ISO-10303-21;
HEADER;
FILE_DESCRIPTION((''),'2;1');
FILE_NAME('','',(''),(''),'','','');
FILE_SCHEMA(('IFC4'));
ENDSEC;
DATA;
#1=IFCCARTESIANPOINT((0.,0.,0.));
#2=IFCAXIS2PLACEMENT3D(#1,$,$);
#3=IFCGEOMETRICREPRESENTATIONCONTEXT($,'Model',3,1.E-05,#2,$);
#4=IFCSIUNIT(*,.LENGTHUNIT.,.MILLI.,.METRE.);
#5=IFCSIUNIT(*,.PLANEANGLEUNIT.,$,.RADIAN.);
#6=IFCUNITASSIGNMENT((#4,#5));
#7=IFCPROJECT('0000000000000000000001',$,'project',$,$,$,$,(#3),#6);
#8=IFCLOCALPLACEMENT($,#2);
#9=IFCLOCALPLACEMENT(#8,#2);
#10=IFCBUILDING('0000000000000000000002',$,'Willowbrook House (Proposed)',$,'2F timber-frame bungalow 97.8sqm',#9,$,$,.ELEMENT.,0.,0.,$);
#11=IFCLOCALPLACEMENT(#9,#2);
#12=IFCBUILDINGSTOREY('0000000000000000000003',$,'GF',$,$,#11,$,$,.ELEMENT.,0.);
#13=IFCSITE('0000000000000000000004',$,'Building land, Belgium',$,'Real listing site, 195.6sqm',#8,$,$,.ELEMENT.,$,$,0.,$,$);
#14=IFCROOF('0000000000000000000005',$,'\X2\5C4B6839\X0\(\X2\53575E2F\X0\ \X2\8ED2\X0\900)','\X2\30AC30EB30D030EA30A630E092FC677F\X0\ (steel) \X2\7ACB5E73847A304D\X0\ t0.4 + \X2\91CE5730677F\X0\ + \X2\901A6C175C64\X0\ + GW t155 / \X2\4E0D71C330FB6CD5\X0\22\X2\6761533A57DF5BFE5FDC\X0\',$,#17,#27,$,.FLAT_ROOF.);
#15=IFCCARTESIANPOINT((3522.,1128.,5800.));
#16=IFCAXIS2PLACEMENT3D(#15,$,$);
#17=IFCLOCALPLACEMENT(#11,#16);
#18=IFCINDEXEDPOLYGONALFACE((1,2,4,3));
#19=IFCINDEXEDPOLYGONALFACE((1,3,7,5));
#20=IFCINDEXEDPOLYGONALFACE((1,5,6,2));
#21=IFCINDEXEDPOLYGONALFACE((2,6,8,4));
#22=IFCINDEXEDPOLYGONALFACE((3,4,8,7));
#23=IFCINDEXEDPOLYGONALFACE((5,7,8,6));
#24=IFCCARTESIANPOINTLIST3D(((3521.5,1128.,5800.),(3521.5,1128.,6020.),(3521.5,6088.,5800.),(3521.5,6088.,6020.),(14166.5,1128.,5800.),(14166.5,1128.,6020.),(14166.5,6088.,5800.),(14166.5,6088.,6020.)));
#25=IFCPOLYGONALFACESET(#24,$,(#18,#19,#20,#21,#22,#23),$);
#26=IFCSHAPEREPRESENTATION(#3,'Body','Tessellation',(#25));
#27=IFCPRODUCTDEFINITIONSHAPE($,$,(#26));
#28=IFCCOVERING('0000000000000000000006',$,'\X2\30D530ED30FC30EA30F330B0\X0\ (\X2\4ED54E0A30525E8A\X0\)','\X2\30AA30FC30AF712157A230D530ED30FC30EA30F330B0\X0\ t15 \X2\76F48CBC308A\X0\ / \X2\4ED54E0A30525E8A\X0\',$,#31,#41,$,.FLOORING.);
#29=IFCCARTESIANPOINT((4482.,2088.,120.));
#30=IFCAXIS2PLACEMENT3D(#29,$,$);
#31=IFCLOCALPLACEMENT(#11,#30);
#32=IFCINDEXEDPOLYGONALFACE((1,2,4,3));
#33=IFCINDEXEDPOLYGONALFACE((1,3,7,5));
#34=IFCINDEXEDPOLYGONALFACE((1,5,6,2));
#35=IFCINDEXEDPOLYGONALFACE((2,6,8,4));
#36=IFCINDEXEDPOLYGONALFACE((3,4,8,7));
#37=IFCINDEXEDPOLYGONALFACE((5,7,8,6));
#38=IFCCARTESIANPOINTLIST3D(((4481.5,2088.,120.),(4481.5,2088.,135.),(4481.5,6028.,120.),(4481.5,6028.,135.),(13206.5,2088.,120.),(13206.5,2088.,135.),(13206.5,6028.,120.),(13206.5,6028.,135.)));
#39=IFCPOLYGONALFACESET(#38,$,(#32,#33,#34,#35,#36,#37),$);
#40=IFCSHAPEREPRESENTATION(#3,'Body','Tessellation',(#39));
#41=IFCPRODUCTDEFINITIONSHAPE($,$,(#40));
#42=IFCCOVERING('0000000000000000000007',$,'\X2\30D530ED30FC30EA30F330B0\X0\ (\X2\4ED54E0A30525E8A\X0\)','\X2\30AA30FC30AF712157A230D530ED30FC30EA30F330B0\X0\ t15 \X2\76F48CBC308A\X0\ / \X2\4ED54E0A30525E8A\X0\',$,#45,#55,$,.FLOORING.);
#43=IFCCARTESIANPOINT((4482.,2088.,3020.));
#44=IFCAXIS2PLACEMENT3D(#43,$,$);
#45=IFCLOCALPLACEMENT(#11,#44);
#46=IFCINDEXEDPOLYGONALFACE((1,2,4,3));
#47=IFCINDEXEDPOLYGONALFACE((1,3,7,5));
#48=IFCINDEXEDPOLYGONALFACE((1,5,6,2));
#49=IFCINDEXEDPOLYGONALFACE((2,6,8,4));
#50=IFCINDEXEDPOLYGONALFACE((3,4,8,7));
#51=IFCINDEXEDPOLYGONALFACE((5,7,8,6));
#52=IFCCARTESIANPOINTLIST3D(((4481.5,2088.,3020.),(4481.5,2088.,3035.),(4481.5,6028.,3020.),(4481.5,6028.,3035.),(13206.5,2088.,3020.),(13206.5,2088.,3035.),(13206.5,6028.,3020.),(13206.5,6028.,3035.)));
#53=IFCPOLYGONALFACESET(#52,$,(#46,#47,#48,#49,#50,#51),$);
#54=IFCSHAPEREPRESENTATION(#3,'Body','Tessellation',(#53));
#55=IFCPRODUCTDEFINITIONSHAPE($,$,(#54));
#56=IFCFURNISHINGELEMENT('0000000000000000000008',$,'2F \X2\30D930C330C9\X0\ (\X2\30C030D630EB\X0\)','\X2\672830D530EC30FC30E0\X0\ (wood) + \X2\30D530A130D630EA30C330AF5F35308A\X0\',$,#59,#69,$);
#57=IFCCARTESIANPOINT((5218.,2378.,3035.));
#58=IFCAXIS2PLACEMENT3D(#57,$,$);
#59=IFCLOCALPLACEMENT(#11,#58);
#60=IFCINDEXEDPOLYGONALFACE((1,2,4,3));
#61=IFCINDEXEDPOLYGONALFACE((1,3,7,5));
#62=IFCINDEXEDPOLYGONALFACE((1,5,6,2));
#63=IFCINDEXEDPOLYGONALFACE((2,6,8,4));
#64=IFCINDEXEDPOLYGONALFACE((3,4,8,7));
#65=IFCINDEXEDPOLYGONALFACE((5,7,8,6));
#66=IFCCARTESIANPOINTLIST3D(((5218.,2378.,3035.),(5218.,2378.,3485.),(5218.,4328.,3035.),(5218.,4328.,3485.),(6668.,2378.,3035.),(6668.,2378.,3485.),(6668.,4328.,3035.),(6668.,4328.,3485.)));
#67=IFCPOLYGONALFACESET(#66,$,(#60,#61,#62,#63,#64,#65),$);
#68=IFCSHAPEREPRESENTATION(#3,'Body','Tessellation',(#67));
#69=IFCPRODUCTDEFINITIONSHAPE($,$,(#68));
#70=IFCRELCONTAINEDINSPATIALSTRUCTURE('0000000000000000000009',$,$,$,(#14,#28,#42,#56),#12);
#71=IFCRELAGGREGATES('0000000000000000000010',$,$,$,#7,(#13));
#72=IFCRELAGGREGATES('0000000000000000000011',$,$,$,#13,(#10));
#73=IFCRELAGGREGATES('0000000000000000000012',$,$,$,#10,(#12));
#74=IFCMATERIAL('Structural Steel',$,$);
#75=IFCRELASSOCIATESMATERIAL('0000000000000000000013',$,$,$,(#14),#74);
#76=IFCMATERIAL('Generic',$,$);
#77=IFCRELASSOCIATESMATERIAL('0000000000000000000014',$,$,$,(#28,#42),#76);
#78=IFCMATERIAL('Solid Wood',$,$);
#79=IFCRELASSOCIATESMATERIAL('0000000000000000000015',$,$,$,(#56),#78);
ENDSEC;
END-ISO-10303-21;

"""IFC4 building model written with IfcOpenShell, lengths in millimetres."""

from ifc_helpers import new_model, si_unit, frame, frame_2d, origin, place, context, project, spatial, rectangle, extrude, material, element, save


model = new_model("IFC4")

# Units and contexts
model_context = context("Model", 3, precision=1e-05, world=origin())
ifc_project = project(units=[si_unit("LENGTHUNIT", "METRE", prefix="MILLI"), si_unit("PLANEANGLEUNIT", "RADIAN")], contexts=[model_context])

# Site, building, storey
site_placement = place(None, origin())
site = spatial("IfcSite", under=ifc_project, at=site_placement, Name="Building land, Belgium", ObjectType="Real listing site, 195.6sqm", CompositionType="ELEMENT", RefElevation=0.0)
building_placement = place(site_placement, origin())
building = spatial("IfcBuilding", under=site, at=building_placement, Name="Willowbrook House (Proposed)", ObjectType="2F timber-frame bungalow 97.8sqm", CompositionType="ELEMENT", ElevationOfRefHeight=0.0, ElevationOfTerrain=0.0)
storey_placement = place(building_placement, origin())
storey = spatial("IfcBuildingStorey", under=building, at=storey_placement, Name="GF", CompositionType="ELEMENT", Elevation=0.0)

# Shared definitions
ifc_material_1 = material(Name="Solid Wood")

# Roof
ifc_material_2 = material(Name="Structural Steel")
for number, where, name in (
    (1, (3522.0, 1128.0, 5800.0), "屋根(南帯 軒900)"),
):
    element("IfcRoof", number, at=place(storey_placement, frame(where)), inside=storey, material=ifc_material_2, Name=name, Description="ガルバリウム鋼板 (steel) 立平葺き t0.4 + 野地板 + 通気層 + GW t155 / 不燃・法22条区域対応", PredefinedType="FLAT_ROOF", context=model_context, shape_type="SweptSolid", body=[
        extrude(rectangle(XDim=10645.0, YDim=4960.0, at=frame_2d((5322.0, 2480.0))), frame((3522.0, 1128.0, 5800.0)), (0.0, 0.0, 1.0), 220.0),
    ])

# Coverings
ifc_material_3 = material(Name="Generic")
covering_1_placement = place(storey_placement, frame((4482.0, 2088.0, 120.0)))
element("IfcCovering", 2, at=covering_1_placement, inside=storey, material=ifc_material_3, Name="フローリング (仕上げ床)", Description="オーク無垢フローリング t15 直貼り / 仕上げ床", PredefinedType="FLOORING", context=model_context, shape_type="SweptSolid", body=[
    extrude(rectangle(XDim=8725.0, YDim=3940.0, at=frame_2d((4362.0, 1970.0))), frame((4482.0, 2088.0, 120.0)), (0.0, 0.0, 1.0), 15.0),
])
covering_2_placement = place(storey_placement, frame((4482.0, 2088.0, 3020.0)))
element("IfcCovering", 3, at=covering_2_placement, inside=storey, material=ifc_material_3, Name="フローリング (仕上げ床)", Description="オーク無垢フローリング t15 直貼り / 仕上げ床", PredefinedType="FLOORING", context=model_context, shape_type="SweptSolid", body=[
    extrude(rectangle(XDim=8725.0, YDim=3940.0, at=frame_2d((4362.0, 1970.0))), frame((4482.0, 2088.0, 3020.0)), (0.0, 0.0, 1.0), 15.0),
])

# Furnishing element
furnishing_placement = place(storey_placement, frame((5218.0, 2378.0, 3035.0)))
element("IfcFurnishingElement", 4, at=furnishing_placement, inside=storey, material=ifc_material_1, Name="2F ベッド (ダブル)", Description="木フレーム (wood) + ファブリック張り", context=model_context, shape_type="SweptSolid", body=[
    extrude(rectangle(XDim=1450.0, YDim=1950.0, at=frame_2d((725.0, 975.0))), frame((5218.0, 2378.0, 3035.0)), (0.0, 0.0, 1.0), 450.0),
])

save(model, "model.ifc")
